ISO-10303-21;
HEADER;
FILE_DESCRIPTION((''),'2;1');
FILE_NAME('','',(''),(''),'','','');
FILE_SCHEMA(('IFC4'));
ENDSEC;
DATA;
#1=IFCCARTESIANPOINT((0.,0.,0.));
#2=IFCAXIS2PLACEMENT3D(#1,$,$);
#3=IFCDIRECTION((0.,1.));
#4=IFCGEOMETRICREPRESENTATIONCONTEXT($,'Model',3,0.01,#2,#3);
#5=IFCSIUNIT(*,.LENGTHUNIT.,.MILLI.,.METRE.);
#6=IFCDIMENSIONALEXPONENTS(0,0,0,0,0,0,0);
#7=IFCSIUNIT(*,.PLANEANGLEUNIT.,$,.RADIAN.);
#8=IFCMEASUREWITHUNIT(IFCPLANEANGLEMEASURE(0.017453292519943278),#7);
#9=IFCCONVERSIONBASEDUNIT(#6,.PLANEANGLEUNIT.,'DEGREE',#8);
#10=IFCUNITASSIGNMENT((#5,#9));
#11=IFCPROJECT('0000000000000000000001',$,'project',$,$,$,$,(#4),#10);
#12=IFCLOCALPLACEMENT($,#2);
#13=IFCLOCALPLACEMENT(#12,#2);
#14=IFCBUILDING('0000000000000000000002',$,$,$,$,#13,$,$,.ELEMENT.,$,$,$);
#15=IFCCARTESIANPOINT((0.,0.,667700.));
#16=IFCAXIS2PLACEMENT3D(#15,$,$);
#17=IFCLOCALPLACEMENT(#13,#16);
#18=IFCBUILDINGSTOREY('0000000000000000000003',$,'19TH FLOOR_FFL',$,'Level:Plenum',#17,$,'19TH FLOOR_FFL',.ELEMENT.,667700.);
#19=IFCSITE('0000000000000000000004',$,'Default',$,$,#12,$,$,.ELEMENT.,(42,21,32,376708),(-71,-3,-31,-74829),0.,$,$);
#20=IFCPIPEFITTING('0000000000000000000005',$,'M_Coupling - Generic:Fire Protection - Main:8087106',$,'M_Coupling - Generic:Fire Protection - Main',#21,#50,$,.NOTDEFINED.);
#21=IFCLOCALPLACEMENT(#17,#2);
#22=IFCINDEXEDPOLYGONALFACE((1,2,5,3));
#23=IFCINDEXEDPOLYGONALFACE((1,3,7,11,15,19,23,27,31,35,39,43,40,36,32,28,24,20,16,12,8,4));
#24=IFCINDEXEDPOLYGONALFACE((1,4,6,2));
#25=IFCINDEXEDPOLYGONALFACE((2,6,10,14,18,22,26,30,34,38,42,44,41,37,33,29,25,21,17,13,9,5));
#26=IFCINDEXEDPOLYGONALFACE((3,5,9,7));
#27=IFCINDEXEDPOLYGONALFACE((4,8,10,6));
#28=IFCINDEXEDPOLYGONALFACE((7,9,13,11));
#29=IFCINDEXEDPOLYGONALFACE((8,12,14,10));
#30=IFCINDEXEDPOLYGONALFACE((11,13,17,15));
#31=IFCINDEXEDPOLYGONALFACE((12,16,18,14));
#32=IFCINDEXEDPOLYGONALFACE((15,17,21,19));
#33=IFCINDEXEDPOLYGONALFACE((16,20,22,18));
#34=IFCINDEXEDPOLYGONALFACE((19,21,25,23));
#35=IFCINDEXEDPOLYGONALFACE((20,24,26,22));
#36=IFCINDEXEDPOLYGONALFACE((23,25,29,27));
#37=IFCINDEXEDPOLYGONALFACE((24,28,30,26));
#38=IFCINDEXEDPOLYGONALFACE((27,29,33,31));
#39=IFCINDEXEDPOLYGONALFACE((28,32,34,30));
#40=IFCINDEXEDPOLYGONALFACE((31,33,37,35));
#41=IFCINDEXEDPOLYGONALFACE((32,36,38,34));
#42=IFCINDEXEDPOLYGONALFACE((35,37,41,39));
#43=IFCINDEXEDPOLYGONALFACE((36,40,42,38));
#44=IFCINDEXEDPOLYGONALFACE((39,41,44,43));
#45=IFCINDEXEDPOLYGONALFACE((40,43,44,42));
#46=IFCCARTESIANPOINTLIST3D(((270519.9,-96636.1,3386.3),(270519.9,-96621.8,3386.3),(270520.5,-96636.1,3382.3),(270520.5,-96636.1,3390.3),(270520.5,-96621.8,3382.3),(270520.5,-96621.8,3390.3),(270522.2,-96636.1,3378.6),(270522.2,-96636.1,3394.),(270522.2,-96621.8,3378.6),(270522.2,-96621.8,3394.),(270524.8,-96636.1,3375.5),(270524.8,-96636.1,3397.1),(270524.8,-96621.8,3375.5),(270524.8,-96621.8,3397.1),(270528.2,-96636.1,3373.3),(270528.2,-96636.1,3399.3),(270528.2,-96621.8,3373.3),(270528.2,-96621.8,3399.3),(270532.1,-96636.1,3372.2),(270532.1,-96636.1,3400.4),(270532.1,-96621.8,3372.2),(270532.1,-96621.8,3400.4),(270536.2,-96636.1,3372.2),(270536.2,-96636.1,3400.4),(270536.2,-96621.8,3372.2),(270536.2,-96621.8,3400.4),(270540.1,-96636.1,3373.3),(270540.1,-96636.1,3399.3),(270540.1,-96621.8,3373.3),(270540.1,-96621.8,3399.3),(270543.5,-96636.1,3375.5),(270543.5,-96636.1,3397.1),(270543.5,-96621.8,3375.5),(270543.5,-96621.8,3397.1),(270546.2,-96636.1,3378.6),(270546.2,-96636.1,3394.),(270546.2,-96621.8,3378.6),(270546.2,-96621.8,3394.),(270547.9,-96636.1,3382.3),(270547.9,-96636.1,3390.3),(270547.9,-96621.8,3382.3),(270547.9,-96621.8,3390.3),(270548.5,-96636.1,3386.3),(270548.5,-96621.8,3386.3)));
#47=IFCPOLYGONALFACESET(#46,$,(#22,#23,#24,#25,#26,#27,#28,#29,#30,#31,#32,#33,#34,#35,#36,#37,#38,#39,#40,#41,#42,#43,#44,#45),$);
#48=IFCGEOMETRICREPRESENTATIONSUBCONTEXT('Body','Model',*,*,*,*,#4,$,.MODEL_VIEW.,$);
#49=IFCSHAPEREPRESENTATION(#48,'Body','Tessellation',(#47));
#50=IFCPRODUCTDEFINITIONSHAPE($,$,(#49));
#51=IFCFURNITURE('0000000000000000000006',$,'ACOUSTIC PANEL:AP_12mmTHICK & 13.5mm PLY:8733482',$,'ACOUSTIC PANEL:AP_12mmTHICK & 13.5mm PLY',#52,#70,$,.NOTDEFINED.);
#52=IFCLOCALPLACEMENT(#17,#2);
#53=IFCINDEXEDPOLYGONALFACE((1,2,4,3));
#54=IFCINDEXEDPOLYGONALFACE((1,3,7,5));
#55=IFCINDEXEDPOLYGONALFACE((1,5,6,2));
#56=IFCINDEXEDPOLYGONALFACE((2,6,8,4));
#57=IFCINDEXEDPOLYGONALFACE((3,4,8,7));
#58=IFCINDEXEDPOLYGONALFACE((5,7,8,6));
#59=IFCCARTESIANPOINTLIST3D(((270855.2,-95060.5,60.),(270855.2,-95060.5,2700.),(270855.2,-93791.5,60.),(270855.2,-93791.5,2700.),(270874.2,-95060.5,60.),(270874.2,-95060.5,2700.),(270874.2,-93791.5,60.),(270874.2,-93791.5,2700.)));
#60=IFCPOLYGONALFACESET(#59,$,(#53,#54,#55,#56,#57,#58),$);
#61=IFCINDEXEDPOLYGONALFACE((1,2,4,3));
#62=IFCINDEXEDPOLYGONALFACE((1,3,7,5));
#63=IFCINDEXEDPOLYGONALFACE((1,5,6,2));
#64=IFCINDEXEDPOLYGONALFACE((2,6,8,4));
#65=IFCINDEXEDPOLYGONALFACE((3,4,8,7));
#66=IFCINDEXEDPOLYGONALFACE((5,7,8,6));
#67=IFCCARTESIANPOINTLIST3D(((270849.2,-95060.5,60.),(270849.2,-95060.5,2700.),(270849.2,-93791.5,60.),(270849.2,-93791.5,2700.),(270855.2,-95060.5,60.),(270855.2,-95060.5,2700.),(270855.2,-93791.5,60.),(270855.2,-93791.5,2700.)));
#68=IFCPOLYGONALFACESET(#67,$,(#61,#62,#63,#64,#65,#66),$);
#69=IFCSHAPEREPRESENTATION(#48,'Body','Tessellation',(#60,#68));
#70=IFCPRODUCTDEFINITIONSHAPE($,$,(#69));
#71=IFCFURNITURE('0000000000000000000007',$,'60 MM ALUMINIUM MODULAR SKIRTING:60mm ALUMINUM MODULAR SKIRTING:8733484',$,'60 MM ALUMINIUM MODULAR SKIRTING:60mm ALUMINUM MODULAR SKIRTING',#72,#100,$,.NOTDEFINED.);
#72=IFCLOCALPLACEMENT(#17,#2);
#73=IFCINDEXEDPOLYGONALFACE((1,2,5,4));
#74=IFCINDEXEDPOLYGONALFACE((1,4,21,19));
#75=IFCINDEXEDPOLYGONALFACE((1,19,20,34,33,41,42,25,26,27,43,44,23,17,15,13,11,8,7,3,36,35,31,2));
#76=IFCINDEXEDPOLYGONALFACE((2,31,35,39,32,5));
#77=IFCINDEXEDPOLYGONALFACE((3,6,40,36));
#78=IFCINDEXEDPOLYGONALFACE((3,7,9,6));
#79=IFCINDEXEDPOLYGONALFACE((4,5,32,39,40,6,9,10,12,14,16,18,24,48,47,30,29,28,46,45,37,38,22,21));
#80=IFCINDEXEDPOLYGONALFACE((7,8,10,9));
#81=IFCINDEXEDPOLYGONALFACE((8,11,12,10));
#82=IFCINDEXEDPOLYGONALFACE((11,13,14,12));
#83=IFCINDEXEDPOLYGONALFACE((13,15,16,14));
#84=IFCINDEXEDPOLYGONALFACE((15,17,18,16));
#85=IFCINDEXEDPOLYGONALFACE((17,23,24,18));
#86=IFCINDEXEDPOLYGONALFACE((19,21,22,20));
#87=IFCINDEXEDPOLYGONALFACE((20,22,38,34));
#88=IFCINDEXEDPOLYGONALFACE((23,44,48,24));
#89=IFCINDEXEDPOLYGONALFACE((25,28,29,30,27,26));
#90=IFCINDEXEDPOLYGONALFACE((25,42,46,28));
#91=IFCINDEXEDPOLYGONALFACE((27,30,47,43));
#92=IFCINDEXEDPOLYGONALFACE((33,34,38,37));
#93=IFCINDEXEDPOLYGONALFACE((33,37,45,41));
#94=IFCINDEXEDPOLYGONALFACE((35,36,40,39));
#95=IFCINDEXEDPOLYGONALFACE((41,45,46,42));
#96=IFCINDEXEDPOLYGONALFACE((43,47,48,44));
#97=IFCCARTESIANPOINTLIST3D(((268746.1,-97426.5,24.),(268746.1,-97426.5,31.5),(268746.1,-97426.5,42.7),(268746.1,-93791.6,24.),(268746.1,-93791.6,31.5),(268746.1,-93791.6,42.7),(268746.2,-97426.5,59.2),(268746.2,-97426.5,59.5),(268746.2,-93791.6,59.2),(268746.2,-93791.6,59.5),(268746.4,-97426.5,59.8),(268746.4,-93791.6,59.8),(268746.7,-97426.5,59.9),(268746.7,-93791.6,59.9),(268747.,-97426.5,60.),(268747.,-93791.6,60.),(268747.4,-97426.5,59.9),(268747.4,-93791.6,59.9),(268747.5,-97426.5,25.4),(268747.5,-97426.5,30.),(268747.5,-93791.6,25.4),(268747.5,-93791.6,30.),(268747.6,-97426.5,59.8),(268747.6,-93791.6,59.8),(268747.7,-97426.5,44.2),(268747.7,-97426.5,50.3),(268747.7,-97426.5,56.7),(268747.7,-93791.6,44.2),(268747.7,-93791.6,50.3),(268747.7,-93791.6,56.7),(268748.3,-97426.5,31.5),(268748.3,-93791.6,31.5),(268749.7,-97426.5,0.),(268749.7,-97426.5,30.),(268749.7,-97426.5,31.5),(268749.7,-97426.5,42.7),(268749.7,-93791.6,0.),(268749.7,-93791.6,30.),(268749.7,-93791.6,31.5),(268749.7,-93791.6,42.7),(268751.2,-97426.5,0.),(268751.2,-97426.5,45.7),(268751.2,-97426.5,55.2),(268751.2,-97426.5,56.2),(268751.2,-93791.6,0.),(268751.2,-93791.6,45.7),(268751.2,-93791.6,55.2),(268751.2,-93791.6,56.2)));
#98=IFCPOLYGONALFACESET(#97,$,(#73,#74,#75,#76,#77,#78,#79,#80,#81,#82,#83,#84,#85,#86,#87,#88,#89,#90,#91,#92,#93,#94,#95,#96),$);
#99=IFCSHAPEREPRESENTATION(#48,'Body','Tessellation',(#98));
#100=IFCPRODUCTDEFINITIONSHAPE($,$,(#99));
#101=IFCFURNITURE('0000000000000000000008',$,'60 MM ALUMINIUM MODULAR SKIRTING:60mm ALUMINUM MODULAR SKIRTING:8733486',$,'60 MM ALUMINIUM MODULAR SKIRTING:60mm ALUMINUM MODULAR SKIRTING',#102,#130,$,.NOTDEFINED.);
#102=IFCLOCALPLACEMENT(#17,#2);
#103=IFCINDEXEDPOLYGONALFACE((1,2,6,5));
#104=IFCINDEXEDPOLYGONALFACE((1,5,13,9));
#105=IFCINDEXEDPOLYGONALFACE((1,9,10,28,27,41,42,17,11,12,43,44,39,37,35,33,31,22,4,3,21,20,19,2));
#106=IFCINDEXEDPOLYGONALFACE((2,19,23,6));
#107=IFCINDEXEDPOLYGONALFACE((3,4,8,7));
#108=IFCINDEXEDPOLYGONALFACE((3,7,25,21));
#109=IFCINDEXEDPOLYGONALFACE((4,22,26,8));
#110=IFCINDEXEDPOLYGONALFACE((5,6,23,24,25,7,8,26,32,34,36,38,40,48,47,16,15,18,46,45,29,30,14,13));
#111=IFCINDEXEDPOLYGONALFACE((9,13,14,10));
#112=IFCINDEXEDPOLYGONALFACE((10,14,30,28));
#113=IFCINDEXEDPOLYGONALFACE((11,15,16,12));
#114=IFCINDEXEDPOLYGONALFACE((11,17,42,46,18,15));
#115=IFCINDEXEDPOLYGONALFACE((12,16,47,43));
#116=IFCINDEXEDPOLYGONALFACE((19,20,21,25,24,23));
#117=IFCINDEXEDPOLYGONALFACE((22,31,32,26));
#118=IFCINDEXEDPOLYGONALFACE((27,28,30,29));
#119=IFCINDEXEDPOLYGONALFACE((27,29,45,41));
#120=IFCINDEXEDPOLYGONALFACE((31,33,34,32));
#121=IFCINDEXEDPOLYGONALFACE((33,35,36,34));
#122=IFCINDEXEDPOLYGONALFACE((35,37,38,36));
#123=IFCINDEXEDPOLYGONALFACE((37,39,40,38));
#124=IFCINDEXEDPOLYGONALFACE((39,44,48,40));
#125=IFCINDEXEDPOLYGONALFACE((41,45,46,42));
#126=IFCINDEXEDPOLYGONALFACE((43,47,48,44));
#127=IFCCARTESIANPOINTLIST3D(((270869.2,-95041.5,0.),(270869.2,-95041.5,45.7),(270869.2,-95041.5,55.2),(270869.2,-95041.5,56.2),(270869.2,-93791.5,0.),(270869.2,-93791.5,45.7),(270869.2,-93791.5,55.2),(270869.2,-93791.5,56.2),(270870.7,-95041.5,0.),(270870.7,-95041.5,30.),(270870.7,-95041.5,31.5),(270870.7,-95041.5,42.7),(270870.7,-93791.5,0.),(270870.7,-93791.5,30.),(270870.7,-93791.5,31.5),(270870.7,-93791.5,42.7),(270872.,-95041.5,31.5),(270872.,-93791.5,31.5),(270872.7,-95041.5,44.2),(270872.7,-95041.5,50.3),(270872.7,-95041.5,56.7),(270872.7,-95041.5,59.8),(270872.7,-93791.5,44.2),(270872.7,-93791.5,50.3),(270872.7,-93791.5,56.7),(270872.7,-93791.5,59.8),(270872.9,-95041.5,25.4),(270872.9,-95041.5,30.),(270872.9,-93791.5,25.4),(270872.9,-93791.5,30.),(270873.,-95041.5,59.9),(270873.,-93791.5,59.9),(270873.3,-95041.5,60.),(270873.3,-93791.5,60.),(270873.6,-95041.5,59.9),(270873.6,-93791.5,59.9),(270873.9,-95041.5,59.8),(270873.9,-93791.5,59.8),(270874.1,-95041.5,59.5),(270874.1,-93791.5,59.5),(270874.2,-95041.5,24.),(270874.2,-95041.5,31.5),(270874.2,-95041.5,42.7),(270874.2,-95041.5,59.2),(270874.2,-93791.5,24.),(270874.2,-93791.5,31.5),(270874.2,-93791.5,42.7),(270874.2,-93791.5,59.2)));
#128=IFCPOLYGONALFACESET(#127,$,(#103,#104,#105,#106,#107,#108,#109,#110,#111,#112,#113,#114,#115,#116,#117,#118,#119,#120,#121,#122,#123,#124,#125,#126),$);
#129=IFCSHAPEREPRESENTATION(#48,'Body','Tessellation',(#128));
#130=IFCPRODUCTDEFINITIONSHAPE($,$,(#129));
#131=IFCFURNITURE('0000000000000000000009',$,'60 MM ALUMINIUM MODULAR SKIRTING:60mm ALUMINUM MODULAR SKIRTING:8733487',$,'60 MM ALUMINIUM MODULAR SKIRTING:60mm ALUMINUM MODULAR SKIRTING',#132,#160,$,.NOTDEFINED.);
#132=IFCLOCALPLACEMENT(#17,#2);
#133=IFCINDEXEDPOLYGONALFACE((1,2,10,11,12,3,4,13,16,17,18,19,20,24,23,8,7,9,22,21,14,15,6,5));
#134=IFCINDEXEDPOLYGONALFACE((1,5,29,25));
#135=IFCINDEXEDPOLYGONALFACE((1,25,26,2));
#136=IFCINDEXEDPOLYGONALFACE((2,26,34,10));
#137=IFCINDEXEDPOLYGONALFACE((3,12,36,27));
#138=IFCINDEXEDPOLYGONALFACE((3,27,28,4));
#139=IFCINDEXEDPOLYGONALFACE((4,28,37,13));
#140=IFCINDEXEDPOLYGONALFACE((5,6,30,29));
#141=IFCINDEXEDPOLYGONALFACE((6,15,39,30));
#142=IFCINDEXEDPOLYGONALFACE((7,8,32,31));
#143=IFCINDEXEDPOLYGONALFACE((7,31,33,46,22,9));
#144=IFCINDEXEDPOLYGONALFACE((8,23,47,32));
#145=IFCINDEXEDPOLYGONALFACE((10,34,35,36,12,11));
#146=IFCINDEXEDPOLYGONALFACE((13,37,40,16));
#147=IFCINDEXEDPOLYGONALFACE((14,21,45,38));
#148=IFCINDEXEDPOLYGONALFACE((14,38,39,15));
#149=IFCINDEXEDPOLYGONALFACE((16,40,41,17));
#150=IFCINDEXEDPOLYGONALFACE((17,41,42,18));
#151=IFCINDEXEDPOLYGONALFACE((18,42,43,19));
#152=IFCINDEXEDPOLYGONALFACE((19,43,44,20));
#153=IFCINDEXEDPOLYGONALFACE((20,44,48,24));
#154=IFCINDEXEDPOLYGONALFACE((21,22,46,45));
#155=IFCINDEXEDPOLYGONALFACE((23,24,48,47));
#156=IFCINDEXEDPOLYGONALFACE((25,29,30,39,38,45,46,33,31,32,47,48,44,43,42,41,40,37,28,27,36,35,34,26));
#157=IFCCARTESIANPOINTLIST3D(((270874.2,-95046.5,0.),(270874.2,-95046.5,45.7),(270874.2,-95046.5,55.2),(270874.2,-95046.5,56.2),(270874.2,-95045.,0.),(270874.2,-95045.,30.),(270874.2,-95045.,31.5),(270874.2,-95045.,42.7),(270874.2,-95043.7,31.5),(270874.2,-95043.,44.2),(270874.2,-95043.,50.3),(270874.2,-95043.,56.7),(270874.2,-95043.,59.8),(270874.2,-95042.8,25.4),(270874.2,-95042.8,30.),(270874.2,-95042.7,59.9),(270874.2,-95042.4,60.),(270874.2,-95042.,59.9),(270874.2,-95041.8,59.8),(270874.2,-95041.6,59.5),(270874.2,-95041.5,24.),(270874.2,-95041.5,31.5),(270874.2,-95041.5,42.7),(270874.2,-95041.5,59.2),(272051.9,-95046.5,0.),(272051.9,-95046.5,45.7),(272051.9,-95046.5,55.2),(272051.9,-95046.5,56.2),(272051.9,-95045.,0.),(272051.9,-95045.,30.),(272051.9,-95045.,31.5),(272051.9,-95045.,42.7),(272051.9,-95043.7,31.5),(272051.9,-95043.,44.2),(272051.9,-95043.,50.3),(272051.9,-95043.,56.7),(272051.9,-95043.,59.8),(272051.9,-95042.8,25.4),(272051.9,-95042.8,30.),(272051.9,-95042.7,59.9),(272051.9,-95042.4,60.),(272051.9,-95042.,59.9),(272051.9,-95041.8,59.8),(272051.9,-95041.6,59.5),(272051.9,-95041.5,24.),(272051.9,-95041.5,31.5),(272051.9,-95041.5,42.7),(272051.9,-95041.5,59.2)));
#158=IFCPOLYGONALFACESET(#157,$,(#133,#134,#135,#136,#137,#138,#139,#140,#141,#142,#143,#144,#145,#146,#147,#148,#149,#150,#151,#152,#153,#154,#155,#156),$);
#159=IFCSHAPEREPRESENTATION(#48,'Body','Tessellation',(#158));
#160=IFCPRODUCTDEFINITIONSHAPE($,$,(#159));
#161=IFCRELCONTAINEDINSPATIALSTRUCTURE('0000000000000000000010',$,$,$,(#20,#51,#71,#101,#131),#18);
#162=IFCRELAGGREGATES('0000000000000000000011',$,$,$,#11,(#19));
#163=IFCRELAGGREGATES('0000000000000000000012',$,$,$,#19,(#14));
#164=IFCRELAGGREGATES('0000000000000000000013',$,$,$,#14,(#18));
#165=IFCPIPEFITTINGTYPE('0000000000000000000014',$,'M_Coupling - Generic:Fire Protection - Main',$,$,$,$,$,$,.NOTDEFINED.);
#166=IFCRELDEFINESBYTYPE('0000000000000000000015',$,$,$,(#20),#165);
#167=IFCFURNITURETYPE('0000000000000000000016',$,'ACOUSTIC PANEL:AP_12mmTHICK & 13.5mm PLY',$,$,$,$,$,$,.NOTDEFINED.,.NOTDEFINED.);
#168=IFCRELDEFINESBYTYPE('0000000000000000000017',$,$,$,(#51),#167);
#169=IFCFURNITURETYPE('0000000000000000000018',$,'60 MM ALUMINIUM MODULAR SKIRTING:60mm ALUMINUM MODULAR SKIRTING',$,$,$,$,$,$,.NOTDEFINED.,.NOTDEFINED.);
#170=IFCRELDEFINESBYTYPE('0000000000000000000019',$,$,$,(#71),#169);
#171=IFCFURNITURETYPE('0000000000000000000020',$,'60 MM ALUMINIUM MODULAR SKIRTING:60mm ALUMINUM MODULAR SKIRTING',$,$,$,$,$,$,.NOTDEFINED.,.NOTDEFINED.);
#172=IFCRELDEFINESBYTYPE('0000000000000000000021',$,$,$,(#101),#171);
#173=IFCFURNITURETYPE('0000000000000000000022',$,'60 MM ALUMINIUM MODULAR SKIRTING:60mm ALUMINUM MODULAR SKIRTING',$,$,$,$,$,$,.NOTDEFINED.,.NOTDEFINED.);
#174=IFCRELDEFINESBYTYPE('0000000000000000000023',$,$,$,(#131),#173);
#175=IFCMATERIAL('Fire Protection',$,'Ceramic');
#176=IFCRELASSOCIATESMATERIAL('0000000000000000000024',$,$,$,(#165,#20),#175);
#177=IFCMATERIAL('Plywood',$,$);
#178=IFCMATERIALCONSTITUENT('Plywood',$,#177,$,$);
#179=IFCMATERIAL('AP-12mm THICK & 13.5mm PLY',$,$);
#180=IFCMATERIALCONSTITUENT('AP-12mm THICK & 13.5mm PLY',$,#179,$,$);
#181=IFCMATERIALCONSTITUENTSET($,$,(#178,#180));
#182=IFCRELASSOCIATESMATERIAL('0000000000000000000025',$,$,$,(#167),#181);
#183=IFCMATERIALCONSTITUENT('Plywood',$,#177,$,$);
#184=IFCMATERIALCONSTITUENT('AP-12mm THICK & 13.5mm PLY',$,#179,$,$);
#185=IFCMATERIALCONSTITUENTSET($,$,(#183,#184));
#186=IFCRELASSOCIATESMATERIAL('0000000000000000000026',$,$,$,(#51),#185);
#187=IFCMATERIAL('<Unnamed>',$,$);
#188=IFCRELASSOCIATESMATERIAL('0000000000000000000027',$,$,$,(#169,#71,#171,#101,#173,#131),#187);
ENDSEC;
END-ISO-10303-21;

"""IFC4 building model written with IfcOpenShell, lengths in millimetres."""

from ifc_helpers import new_model, entity, si_unit, converted_unit, direction, frame, origin, place, context, subcontext, project, spatial, line, arc, indexed_curve, outline, extrude, source, transform, mapped, material, constituent, constituent_set, type_object, type_shapes, element, save


model = new_model("IFC4")

# Units and contexts
model_context = context("Model", 3, precision=0.01, world=origin(), true_north=direction((0.0, 1.0)))
body_context = subcontext(model_context, "Body", "Model", "MODEL_VIEW")
ifc_project = project(units=[si_unit("LENGTHUNIT", "METRE", prefix="MILLI"), converted_unit("PLANEANGLEUNIT", "DEGREE", entity("IfcPlaneAngleMeasure", 0.017453292519943278), si_unit("PLANEANGLEUNIT", "RADIAN"), dimensions=[0, 0, 0, 0, 0, 0, 0])], contexts=[model_context])

# Site, building, storey
site_placement = place(None, origin())
site = spatial("IfcSite", under=ifc_project, at=site_placement, Name="Default", CompositionType="ELEMENT", RefLatitude=(42, 21, 32, 376708), RefLongitude=(-71, -3, -31, -74829), RefElevation=0.0)
building_placement = place(site_placement, origin())
building = spatial("IfcBuilding", under=site, at=building_placement, CompositionType="ELEMENT")
storey_placement = place(building_placement, frame((0.0, 0.0, 667700.0)))
storey = spatial("IfcBuildingStorey", under=building, at=storey_placement, Name="19TH FLOOR_FFL", ObjectType="Level:Plenum", LongName="19TH FLOOR_FFL", CompositionType="ELEMENT", Elevation=667700.0)

# Shared definitions
ifc_material_1 = material(Name="<Unnamed>")

# Pipe fitting
ifc_material_2 = material(Name="Fire Protection", Category="Ceramic")
pipe_fitting_type = type_object("IfcPipeFittingType", Name="M_Coupling - Generic:Fire Protection - Main", PredefinedType="NOTDEFINED", material=ifc_material_2)
shared_shape_1 = source(origin(), body_context, "Body", "SweptSolid", [
    extrude(outline(indexed_curve([(-14.3, 0.0), (0.0, -14.3), (14.3, 0.0), (0.0, 14.3)], segments=[arc(1, 2, 3), arc(3, 4, 1)], self_intersect=False)), frame((-7.1, 0.0, 0.0), z_axis=(1.0, 0.0, 0.0), x_axis=(0.0, 1.0, 0.0)), (0.0, 0.0, 1.0), 14.3),
])
type_shapes(pipe_fitting_type, [shared_shape_1])
pipe_fitting_placement = place(storey_placement, frame((270534.2, -96629.0, 3386.3), z_axis=(0.0, 0.000036, 1.0), x_axis=(0.0, 1.0, -0.000036)))
element("IfcPipeFitting", 1, at=pipe_fitting_placement, inside=storey, type_object=pipe_fitting_type, material=ifc_material_2, Name="M_Coupling - Generic:Fire Protection - Main:8087106", ObjectType="M_Coupling - Generic:Fire Protection - Main", PredefinedType="NOTDEFINED", context=body_context, shape_type="MappedRepresentation", body=[
    mapped(shared_shape_1, transform((0.0, 0.0, 0.0), scale=1.0)),
])

# Furniture
ifc_material_3 = material(Name="Plywood")
ifc_constituent_1 = constituent(ifc_material_3, Name="Plywood")
ifc_material_4 = material(Name="AP-12mm THICK & 13.5mm PLY")
ifc_constituent_2 = constituent(ifc_material_4, Name="AP-12mm THICK & 13.5mm PLY")
ifc_constituent_set_1 = constituent_set(constituents=[ifc_constituent_1, ifc_constituent_2])
ifc_constituent_3 = constituent(ifc_material_3, Name="Plywood")
ifc_constituent_4 = constituent(ifc_material_4, Name="AP-12mm THICK & 13.5mm PLY")
ifc_constituent_set_2 = constituent_set(constituents=[ifc_constituent_3, ifc_constituent_4])
furniture_type_1 = type_object("IfcFurnitureType", Name="ACOUSTIC PANEL:AP_12mmTHICK & 13.5mm PLY", AssemblyPlace="NOTDEFINED", PredefinedType="NOTDEFINED", material=ifc_constituent_set_2)
shared_shape_2 = source(origin(), body_context, "Body", "SweptSolid", [
    extrude(outline(indexed_curve([(-634.5, -1320.0), (634.5, -1320.0), (634.5, 1320.0), (-634.5, 1320.0), (-634.5, -1320.0)], self_intersect=False)), frame((0.0, 1320.0, 0.0), z_axis=(0.0, 0.0, 1.0), x_axis=(-1.0, 0.0, 0.0)), (0.0, 0.0, 1.0), 19.0),
    extrude(outline(indexed_curve([(-634.5, -1320.0), (634.5, -1320.0), (634.5, 1320.0), (-634.5, 1320.0), (-634.5, -1320.0)], self_intersect=False)), frame((0.0, 1320.0, 19.0), z_axis=(0.0, 0.0, 1.0), x_axis=(-1.0, 0.0, 0.0)), (0.0, 0.0, 1.0), 6.0),
])
type_shapes(furniture_type_1, [shared_shape_2])
furniture_1_placement = place(storey_placement, frame((270874.2, -94426.0, 60.0), z_axis=(-1.0, 0.0, 0.0), x_axis=(0.0, -1.0, 0.0)))
element("IfcFurniture", 2, at=furniture_1_placement, inside=storey, type_object=furniture_type_1, material=ifc_constituent_set_1, Name="ACOUSTIC PANEL:AP_12mmTHICK & 13.5mm PLY:8733482", ObjectType="ACOUSTIC PANEL:AP_12mmTHICK & 13.5mm PLY", PredefinedType="NOTDEFINED", context=body_context, shape_type="MappedRepresentation", body=[
    mapped(shared_shape_2, transform((0.0, 0.0, 0.0), scale=1.0)),
])
furniture_type_2 = type_object("IfcFurnitureType", Name="60 MM ALUMINIUM MODULAR SKIRTING:60mm ALUMINUM MODULAR SKIRTING", AssemblyPlace="NOTDEFINED", PredefinedType="NOTDEFINED", material=ifc_material_1)
shared_shape_3 = source(origin(), body_context, "Body", "SweptSolid", [
    extrude(outline(indexed_curve([(-18.5, -2.7), (-17.5, -2.7), (-19.0, 0.8), (-12.6, 0.8), (-6.5, 0.8), (-8.0, -2.7), (37.7, -2.7), (37.7, -1.2), (7.7, -1.2), (7.7, 1.0), (12.3, 1.0), (13.7, 2.4), (6.2, 2.4), (6.2, 0.2), (6.2, -1.2), (-5.0, -1.2), (-5.0, 2.4), (-21.4, 2.3), (-22.2, 1.8), (-22.0, 0.9)], segments=[line(1, 2, 3, 4, 5, 6, 7, 8, 9, 10, 11, 12, 13, 14, 15, 16, 17, 18), arc(18, 19, 20), line(20, 1)], self_intersect=False)), frame((0.0, -2.4, 37.7), z_axis=(1.0, 0.0, 0.0), x_axis=(0.0, 0.0, -1.0)), (0.0, 0.0, 1.0), 3634.8),
])
type_shapes(furniture_type_2, [shared_shape_3])
furniture_2_placement = place(storey_placement, frame((268746.1, -97426.5, 0.0), z_axis=(0.0, 0.0, 1.0), x_axis=(0.0, 1.0, 0.0)))
element("IfcFurniture", 3, at=furniture_2_placement, inside=storey, type_object=furniture_type_2, material=ifc_material_1, Name="60 MM ALUMINIUM MODULAR SKIRTING:60mm ALUMINUM MODULAR SKIRTING:8733484", ObjectType="60 MM ALUMINIUM MODULAR SKIRTING:60mm ALUMINUM MODULAR SKIRTING", PredefinedType="NOTDEFINED", context=body_context, shape_type="MappedRepresentation", body=[
    mapped(shared_shape_3, transform((0.0, 0.0, 0.0), scale=1.0)),
])
furniture_type_3 = type_object("IfcFurnitureType", Name="60 MM ALUMINIUM MODULAR SKIRTING:60mm ALUMINUM MODULAR SKIRTING", AssemblyPlace="NOTDEFINED", PredefinedType="NOTDEFINED", material=ifc_material_1)
shared_shape_4 = source(origin(), body_context, "Body", "SweptSolid", [
    extrude(outline(indexed_curve([(-18.5, -2.7), (-17.5, -2.7), (-19.0, 0.8), (-12.6, 0.8), (-6.5, 0.8), (-8.0, -2.7), (37.7, -2.7), (37.7, -1.2), (7.7, -1.2), (7.7, 1.0), (12.3, 1.0), (13.7, 2.4), (6.2, 2.4), (6.2, 0.2), (6.2, -1.2), (-5.0, -1.2), (-5.0, 2.4), (-21.4, 2.3), (-22.2, 1.8), (-22.0, 0.9)], segments=[line(1, 2, 3, 4, 5, 6, 7, 8, 9, 10, 11, 12, 13, 14, 15, 16, 17, 18), arc(18, 19, 20), line(20, 1)], self_intersect=False)), frame((0.0, -2.4, 37.7), z_axis=(1.0, 0.0, 0.0), x_axis=(0.0, 0.0, -1.0)), (0.0, 0.0, 1.0), 1250.0),
])
type_shapes(furniture_type_3, [shared_shape_4])
furniture_3_placement = place(storey_placement, frame((270874.2, -93791.5, 0.0), z_axis=(0.0, 0.0, 1.0), x_axis=(0.0, -1.0, 0.0)))
element("IfcFurniture", 4, at=furniture_3_placement, inside=storey, type_object=furniture_type_3, material=ifc_material_1, Name="60 MM ALUMINIUM MODULAR SKIRTING:60mm ALUMINUM MODULAR SKIRTING:8733486", ObjectType="60 MM ALUMINIUM MODULAR SKIRTING:60mm ALUMINUM MODULAR SKIRTING", PredefinedType="NOTDEFINED", context=body_context, shape_type="MappedRepresentation", body=[
    mapped(shared_shape_4, transform((0.0, 0.0, 0.0), scale=1.0)),
])
furniture_type_4 = type_object("IfcFurnitureType", Name="60 MM ALUMINIUM MODULAR SKIRTING:60mm ALUMINUM MODULAR SKIRTING", AssemblyPlace="NOTDEFINED", PredefinedType="NOTDEFINED", material=ifc_material_1)
shared_shape_5 = source(origin(), body_context, "Body", "SweptSolid", [
    extrude(outline(indexed_curve([(-18.5, -2.7), (-17.5, -2.7), (-19.0, 0.8), (-12.6, 0.8), (-6.5, 0.8), (-8.0, -2.7), (37.7, -2.7), (37.7, -1.2), (7.7, -1.2), (7.7, 1.0), (12.3, 1.0), (13.7, 2.4), (6.2, 2.4), (6.2, 0.2), (6.2, -1.2), (-5.0, -1.2), (-5.0, 2.4), (-21.4, 2.3), (-22.2, 1.8), (-22.0, 0.9)], segments=[line(1, 2, 3, 4, 5, 6, 7, 8, 9, 10, 11, 12, 13, 14, 15, 16, 17, 18), arc(18, 19, 20), line(20, 1)], self_intersect=False)), frame((0.0, -2.4, 37.7), z_axis=(1.0, 0.0, 0.0), x_axis=(0.0, 0.0, -1.0)), (0.0, 0.0, 1.0), 1177.7),
])
type_shapes(furniture_type_4, [shared_shape_5])
furniture_4_placement = place(storey_placement, frame((270874.2, -95041.5, 0.0)))
element("IfcFurniture", 5, at=furniture_4_placement, inside=storey, type_object=furniture_type_4, material=ifc_material_1, Name="60 MM ALUMINIUM MODULAR SKIRTING:60mm ALUMINUM MODULAR SKIRTING:8733487", ObjectType="60 MM ALUMINIUM MODULAR SKIRTING:60mm ALUMINUM MODULAR SKIRTING", PredefinedType="NOTDEFINED", context=body_context, shape_type="MappedRepresentation", body=[
    mapped(shared_shape_5, transform((0.0, 0.0, 0.0), scale=1.0)),
])

save(model, "model.ifc")
